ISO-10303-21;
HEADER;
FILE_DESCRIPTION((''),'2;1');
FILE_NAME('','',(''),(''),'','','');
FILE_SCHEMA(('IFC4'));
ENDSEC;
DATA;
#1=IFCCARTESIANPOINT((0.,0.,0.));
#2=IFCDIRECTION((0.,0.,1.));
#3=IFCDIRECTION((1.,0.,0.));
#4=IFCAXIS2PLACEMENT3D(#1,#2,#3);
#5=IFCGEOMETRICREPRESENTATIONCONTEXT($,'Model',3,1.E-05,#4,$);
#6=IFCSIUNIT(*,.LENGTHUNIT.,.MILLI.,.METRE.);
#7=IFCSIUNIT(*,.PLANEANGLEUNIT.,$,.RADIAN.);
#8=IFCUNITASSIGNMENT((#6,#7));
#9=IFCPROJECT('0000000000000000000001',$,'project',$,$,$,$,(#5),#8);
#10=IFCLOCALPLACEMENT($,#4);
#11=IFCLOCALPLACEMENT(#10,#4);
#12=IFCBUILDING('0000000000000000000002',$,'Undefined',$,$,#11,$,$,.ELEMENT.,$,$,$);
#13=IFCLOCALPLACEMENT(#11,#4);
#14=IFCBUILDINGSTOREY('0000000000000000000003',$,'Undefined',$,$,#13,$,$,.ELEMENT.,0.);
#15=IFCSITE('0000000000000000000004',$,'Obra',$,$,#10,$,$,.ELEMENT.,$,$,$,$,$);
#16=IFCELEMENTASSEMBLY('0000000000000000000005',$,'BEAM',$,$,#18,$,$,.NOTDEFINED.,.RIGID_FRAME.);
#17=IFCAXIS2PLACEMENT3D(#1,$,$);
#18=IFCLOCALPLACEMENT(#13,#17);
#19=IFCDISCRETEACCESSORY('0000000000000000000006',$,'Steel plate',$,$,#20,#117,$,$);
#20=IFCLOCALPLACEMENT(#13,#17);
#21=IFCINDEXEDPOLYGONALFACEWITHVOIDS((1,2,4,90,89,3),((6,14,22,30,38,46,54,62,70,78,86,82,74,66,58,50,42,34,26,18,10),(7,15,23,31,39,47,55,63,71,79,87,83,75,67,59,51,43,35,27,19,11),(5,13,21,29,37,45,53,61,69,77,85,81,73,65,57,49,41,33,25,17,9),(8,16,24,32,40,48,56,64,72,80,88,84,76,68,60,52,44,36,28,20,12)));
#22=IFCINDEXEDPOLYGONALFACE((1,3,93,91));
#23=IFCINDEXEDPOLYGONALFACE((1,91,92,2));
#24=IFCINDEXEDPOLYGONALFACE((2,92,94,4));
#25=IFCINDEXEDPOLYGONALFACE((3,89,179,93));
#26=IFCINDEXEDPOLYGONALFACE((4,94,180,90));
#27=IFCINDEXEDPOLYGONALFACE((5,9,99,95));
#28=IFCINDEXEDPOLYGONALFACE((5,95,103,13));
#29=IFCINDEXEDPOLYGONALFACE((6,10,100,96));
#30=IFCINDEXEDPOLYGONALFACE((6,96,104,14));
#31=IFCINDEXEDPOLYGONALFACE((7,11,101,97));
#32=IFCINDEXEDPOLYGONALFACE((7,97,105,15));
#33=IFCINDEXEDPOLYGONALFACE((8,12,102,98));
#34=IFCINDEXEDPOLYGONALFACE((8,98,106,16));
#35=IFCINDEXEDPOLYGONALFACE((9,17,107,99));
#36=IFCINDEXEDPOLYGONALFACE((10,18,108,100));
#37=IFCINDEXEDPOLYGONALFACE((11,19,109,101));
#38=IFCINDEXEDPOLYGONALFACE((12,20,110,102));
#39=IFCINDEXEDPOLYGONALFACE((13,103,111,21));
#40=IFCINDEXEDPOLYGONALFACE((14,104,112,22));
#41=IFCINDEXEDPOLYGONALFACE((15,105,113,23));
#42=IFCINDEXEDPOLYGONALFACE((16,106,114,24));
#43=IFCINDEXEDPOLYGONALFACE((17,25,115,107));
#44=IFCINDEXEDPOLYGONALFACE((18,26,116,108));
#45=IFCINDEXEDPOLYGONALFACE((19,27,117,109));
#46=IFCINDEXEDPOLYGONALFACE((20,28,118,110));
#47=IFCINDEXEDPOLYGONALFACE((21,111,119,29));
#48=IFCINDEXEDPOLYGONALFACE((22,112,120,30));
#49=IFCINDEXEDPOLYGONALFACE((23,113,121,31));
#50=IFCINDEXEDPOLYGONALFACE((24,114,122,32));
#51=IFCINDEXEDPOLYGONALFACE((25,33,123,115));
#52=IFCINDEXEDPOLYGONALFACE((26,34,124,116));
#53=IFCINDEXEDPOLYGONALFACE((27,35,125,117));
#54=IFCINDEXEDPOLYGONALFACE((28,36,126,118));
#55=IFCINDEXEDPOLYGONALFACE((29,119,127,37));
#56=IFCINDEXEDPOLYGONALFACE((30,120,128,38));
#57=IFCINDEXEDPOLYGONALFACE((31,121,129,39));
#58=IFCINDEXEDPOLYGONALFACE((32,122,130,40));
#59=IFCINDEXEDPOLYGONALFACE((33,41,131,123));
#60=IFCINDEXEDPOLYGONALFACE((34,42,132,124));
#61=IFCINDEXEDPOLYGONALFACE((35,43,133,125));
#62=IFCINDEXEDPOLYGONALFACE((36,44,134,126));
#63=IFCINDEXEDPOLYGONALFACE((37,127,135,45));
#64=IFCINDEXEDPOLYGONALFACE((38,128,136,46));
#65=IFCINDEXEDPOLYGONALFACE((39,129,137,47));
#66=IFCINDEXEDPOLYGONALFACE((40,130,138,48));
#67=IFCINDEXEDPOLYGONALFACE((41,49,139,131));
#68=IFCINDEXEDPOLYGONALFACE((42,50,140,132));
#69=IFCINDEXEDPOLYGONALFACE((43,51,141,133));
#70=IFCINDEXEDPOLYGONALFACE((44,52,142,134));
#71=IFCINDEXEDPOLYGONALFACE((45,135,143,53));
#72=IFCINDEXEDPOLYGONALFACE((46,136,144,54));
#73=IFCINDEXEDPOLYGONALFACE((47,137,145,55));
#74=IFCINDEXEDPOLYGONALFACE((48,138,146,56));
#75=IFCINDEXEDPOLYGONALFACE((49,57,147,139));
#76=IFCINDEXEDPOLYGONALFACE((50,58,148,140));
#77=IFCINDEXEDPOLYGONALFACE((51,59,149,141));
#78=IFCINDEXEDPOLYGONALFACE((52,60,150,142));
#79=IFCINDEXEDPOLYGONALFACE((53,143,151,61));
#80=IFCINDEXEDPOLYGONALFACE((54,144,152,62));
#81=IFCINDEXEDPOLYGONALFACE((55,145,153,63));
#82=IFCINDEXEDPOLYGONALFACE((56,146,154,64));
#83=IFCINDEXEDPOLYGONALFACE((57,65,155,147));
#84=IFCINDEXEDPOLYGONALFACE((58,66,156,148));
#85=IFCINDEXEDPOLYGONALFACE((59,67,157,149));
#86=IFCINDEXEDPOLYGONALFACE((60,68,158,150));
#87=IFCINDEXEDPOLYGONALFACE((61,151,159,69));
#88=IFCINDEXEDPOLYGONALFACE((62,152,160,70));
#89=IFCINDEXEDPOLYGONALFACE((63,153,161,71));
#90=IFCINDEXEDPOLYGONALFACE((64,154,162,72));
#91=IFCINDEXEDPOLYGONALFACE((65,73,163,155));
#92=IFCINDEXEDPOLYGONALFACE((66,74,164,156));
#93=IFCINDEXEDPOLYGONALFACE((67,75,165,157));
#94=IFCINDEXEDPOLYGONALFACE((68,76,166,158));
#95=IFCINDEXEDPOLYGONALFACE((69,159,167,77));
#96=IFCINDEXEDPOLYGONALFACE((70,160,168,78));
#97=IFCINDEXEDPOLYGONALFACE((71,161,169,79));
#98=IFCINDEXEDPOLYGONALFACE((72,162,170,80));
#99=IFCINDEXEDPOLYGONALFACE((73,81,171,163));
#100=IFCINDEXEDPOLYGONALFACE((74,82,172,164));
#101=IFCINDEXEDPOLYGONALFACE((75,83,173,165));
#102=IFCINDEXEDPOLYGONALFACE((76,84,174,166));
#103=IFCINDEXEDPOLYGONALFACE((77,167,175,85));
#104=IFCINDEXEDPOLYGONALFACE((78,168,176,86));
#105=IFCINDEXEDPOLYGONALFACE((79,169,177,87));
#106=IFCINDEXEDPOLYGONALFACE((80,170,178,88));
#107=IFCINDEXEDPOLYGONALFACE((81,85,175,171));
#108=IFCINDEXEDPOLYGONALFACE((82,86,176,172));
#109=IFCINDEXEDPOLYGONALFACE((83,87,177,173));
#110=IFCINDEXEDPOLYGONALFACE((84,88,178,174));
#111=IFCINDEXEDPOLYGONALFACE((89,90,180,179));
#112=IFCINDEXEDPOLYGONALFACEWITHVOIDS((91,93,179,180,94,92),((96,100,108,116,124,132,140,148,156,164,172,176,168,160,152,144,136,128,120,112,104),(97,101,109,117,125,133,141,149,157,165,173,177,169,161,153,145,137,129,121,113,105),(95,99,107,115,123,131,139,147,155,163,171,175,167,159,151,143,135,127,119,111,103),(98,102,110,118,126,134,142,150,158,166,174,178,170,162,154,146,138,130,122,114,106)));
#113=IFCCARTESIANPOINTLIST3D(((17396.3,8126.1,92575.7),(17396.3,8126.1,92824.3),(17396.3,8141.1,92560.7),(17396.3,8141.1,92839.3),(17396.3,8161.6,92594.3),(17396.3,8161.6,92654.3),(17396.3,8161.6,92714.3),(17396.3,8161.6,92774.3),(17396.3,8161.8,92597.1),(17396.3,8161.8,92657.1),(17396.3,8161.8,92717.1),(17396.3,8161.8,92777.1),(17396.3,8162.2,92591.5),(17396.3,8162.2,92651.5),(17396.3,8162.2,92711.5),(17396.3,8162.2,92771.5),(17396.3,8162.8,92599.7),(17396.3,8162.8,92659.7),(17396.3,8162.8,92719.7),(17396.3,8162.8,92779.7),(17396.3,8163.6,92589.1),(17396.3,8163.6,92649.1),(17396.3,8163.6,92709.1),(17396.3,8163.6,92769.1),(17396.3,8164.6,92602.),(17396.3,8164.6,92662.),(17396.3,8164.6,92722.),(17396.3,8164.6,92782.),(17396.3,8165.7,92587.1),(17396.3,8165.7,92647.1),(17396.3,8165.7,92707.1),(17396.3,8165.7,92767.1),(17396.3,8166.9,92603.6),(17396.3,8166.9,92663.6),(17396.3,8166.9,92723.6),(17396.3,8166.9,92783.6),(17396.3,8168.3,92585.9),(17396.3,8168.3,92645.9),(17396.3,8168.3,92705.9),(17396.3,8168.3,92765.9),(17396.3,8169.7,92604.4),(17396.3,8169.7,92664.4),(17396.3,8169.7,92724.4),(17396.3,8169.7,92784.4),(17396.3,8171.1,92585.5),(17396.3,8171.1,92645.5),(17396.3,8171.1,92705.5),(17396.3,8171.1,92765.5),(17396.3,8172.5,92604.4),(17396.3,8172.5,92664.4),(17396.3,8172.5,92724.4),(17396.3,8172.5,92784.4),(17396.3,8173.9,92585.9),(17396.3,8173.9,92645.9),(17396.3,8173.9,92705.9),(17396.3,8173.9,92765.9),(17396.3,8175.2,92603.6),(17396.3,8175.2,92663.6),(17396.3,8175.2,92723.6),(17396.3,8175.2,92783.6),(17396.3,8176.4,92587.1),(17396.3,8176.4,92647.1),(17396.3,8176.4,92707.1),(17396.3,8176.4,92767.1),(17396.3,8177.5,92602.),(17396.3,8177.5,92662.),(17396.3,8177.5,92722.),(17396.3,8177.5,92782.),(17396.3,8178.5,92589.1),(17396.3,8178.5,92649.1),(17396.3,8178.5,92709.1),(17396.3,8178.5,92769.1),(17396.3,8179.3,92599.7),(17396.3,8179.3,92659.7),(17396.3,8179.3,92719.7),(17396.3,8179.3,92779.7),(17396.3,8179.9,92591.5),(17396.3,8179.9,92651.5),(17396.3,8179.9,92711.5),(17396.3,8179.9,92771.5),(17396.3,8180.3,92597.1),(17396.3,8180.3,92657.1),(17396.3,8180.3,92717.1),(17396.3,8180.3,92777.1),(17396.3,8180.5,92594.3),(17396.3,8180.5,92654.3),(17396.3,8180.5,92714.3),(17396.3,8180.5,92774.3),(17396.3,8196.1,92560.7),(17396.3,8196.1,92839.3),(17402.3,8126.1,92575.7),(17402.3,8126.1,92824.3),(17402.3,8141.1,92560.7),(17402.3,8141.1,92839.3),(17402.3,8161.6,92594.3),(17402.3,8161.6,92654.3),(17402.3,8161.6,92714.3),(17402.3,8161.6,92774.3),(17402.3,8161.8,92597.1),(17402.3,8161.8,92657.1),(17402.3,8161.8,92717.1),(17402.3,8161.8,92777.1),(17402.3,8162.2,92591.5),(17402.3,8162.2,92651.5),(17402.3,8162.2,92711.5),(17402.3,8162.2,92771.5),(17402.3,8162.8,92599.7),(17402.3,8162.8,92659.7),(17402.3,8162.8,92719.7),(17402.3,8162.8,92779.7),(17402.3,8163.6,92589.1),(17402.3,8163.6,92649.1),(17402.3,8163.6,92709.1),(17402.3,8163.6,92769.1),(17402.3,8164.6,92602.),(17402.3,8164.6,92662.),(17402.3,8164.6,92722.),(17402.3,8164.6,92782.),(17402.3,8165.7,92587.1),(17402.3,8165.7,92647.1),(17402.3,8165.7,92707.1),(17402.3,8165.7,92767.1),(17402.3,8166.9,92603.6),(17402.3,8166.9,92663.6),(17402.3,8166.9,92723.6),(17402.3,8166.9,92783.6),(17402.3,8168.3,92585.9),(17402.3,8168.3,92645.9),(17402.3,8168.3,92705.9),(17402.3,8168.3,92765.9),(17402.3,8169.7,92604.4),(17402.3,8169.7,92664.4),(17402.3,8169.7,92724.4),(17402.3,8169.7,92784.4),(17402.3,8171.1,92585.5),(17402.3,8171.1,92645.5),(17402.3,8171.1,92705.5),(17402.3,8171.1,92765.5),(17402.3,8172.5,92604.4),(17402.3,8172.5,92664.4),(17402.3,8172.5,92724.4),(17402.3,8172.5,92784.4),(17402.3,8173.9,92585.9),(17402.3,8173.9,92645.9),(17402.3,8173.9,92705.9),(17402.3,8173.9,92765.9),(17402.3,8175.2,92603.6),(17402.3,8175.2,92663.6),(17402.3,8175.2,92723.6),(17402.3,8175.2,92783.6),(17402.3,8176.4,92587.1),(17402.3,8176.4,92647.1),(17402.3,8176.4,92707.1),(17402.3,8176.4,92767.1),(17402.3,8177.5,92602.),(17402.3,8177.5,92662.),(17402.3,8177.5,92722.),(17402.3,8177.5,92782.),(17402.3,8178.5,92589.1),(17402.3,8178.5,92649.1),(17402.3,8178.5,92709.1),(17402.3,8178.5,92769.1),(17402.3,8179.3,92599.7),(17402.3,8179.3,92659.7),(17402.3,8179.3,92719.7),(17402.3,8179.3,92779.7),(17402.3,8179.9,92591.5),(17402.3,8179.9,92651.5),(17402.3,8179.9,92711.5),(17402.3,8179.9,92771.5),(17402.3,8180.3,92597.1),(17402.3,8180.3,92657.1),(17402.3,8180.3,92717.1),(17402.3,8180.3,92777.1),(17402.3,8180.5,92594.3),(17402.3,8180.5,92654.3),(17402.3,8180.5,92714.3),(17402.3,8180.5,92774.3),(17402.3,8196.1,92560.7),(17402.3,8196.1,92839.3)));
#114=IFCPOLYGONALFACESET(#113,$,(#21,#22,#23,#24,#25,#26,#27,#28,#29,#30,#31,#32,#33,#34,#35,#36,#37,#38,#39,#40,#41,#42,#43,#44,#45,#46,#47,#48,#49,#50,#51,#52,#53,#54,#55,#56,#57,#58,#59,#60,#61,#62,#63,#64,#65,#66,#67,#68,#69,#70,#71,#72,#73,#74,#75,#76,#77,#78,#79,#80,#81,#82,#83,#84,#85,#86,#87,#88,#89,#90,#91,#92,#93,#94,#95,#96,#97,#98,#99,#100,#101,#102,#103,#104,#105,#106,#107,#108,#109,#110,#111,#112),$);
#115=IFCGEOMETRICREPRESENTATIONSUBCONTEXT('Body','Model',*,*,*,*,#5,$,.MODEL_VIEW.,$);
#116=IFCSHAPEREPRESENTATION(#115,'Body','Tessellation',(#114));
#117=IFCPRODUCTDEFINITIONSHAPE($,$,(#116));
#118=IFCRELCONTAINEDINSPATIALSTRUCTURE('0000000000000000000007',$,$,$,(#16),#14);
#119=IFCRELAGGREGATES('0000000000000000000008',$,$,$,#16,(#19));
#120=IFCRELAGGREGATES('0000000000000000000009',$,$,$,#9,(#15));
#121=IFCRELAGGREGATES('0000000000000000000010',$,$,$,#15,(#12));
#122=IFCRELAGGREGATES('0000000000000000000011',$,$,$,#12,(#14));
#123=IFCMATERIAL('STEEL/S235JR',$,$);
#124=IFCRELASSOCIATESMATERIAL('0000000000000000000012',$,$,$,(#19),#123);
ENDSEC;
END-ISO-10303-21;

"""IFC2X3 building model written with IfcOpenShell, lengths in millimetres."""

from ifc_helpers import new_model, si_unit, frame, origin_with_axes, origin_2d_with_axis, place, context, subcontext, project, spatial, polyline, circle, outline, extrude, source, transform, mapped, material, element, aggregate, save


model = new_model("IFC2X3")

# Units and contexts
model_context = context("Model", 3, precision=1e-05, world=origin_with_axes())
body_context = subcontext(model_context, "Body", "Model", "MODEL_VIEW")
ifc_project = project(units=[si_unit("LENGTHUNIT", "METRE", prefix="MILLI"), si_unit("PLANEANGLEUNIT", "RADIAN")], contexts=[model_context])

# Site, building, storey
site_placement = place(None, origin_with_axes())
site = spatial("IfcSite", under=ifc_project, at=site_placement, Name="Obra", CompositionType="ELEMENT")
building_placement = place(site_placement, origin_with_axes())
building = spatial("IfcBuilding", under=site, at=building_placement, Name="Undefined", CompositionType="ELEMENT")
storey_placement = place(building_placement, origin_with_axes())
storey = spatial("IfcBuildingStorey", under=building, at=storey_placement, Name="Undefined", CompositionType="ELEMENT", Elevation=0.0)

# Element assembly, discrete accessory, opening
ifc_material_1 = material(Name="STEEL/S235JR")
shared_shape_1 = source(origin_with_axes(), body_context, "Body", "SweptSolid", [
    extrude(circle(Radius=9.5, at=origin_2d_with_axis()), frame((0.0, -9.8, 0.0), z_axis=(0.0, 1.0, 0.0), x_axis=(1.0, 0.0, 0.0)), (0.0, 0.0, 1.0), 6.2),
])
assembly_1_placement = place(storey_placement, origin_with_axes())
assembly_1 = element("IfcElementAssembly", 1, at=assembly_1_placement, inside=storey, Name="BEAM", AssemblyPlace="NOTDEFINED", PredefinedType="RIGID_FRAME")
discrete_accessory_1_placement = place(assembly_1_placement, frame((17399.3, 8196.1, 92560.7), z_axis=(-1.0, 0.0, 0.0), x_axis=(0.0, -1.0, 0.0)))
discrete_accessory_1 = element("IfcDiscreteAccessory", 2, at=discrete_accessory_1_placement, material=ifc_material_1, Name="Steel plate", context=body_context, shape_type="SweptSolid", body=[
    extrude(outline(polyline([(0.0, 0.0), (55.0, 0.0), (70.0, 15.0), (70.0, 263.6), (55.0, 278.6), (0.0, 278.6), (0.0, 0.0)])), frame((0.0, 0.0, -3.0), z_axis=(0.0, 0.0, 1.0), x_axis=(1.0, 0.0, 0.0)), (0.0, 0.0, 1.0), 6.0),
])
opening_1_placement = place(assembly_1_placement, frame((17392.6, 8136.1, 92850.0), z_axis=(0.0, 1.0, 0.0), x_axis=(0.0, 0.0, -1.0)))
element("IfcOpeningElement", 3, at=opening_1_placement, cuts=discrete_accessory_1, ObjectType="Opening", context=body_context, shape_type="MappedRepresentation", body=[
    mapped(shared_shape_1, transform((75.0, 0.0, 35.0))),
    mapped(shared_shape_1, transform((135.0, 0.0, 35.0))),
    mapped(shared_shape_1, transform((195.0, 0.0, 35.0))),
    mapped(shared_shape_1, transform((255.0, 0.0, 35.0))),
])

aggregate(assembly_1, [discrete_accessory_1])

save(model, "model.ifc")
